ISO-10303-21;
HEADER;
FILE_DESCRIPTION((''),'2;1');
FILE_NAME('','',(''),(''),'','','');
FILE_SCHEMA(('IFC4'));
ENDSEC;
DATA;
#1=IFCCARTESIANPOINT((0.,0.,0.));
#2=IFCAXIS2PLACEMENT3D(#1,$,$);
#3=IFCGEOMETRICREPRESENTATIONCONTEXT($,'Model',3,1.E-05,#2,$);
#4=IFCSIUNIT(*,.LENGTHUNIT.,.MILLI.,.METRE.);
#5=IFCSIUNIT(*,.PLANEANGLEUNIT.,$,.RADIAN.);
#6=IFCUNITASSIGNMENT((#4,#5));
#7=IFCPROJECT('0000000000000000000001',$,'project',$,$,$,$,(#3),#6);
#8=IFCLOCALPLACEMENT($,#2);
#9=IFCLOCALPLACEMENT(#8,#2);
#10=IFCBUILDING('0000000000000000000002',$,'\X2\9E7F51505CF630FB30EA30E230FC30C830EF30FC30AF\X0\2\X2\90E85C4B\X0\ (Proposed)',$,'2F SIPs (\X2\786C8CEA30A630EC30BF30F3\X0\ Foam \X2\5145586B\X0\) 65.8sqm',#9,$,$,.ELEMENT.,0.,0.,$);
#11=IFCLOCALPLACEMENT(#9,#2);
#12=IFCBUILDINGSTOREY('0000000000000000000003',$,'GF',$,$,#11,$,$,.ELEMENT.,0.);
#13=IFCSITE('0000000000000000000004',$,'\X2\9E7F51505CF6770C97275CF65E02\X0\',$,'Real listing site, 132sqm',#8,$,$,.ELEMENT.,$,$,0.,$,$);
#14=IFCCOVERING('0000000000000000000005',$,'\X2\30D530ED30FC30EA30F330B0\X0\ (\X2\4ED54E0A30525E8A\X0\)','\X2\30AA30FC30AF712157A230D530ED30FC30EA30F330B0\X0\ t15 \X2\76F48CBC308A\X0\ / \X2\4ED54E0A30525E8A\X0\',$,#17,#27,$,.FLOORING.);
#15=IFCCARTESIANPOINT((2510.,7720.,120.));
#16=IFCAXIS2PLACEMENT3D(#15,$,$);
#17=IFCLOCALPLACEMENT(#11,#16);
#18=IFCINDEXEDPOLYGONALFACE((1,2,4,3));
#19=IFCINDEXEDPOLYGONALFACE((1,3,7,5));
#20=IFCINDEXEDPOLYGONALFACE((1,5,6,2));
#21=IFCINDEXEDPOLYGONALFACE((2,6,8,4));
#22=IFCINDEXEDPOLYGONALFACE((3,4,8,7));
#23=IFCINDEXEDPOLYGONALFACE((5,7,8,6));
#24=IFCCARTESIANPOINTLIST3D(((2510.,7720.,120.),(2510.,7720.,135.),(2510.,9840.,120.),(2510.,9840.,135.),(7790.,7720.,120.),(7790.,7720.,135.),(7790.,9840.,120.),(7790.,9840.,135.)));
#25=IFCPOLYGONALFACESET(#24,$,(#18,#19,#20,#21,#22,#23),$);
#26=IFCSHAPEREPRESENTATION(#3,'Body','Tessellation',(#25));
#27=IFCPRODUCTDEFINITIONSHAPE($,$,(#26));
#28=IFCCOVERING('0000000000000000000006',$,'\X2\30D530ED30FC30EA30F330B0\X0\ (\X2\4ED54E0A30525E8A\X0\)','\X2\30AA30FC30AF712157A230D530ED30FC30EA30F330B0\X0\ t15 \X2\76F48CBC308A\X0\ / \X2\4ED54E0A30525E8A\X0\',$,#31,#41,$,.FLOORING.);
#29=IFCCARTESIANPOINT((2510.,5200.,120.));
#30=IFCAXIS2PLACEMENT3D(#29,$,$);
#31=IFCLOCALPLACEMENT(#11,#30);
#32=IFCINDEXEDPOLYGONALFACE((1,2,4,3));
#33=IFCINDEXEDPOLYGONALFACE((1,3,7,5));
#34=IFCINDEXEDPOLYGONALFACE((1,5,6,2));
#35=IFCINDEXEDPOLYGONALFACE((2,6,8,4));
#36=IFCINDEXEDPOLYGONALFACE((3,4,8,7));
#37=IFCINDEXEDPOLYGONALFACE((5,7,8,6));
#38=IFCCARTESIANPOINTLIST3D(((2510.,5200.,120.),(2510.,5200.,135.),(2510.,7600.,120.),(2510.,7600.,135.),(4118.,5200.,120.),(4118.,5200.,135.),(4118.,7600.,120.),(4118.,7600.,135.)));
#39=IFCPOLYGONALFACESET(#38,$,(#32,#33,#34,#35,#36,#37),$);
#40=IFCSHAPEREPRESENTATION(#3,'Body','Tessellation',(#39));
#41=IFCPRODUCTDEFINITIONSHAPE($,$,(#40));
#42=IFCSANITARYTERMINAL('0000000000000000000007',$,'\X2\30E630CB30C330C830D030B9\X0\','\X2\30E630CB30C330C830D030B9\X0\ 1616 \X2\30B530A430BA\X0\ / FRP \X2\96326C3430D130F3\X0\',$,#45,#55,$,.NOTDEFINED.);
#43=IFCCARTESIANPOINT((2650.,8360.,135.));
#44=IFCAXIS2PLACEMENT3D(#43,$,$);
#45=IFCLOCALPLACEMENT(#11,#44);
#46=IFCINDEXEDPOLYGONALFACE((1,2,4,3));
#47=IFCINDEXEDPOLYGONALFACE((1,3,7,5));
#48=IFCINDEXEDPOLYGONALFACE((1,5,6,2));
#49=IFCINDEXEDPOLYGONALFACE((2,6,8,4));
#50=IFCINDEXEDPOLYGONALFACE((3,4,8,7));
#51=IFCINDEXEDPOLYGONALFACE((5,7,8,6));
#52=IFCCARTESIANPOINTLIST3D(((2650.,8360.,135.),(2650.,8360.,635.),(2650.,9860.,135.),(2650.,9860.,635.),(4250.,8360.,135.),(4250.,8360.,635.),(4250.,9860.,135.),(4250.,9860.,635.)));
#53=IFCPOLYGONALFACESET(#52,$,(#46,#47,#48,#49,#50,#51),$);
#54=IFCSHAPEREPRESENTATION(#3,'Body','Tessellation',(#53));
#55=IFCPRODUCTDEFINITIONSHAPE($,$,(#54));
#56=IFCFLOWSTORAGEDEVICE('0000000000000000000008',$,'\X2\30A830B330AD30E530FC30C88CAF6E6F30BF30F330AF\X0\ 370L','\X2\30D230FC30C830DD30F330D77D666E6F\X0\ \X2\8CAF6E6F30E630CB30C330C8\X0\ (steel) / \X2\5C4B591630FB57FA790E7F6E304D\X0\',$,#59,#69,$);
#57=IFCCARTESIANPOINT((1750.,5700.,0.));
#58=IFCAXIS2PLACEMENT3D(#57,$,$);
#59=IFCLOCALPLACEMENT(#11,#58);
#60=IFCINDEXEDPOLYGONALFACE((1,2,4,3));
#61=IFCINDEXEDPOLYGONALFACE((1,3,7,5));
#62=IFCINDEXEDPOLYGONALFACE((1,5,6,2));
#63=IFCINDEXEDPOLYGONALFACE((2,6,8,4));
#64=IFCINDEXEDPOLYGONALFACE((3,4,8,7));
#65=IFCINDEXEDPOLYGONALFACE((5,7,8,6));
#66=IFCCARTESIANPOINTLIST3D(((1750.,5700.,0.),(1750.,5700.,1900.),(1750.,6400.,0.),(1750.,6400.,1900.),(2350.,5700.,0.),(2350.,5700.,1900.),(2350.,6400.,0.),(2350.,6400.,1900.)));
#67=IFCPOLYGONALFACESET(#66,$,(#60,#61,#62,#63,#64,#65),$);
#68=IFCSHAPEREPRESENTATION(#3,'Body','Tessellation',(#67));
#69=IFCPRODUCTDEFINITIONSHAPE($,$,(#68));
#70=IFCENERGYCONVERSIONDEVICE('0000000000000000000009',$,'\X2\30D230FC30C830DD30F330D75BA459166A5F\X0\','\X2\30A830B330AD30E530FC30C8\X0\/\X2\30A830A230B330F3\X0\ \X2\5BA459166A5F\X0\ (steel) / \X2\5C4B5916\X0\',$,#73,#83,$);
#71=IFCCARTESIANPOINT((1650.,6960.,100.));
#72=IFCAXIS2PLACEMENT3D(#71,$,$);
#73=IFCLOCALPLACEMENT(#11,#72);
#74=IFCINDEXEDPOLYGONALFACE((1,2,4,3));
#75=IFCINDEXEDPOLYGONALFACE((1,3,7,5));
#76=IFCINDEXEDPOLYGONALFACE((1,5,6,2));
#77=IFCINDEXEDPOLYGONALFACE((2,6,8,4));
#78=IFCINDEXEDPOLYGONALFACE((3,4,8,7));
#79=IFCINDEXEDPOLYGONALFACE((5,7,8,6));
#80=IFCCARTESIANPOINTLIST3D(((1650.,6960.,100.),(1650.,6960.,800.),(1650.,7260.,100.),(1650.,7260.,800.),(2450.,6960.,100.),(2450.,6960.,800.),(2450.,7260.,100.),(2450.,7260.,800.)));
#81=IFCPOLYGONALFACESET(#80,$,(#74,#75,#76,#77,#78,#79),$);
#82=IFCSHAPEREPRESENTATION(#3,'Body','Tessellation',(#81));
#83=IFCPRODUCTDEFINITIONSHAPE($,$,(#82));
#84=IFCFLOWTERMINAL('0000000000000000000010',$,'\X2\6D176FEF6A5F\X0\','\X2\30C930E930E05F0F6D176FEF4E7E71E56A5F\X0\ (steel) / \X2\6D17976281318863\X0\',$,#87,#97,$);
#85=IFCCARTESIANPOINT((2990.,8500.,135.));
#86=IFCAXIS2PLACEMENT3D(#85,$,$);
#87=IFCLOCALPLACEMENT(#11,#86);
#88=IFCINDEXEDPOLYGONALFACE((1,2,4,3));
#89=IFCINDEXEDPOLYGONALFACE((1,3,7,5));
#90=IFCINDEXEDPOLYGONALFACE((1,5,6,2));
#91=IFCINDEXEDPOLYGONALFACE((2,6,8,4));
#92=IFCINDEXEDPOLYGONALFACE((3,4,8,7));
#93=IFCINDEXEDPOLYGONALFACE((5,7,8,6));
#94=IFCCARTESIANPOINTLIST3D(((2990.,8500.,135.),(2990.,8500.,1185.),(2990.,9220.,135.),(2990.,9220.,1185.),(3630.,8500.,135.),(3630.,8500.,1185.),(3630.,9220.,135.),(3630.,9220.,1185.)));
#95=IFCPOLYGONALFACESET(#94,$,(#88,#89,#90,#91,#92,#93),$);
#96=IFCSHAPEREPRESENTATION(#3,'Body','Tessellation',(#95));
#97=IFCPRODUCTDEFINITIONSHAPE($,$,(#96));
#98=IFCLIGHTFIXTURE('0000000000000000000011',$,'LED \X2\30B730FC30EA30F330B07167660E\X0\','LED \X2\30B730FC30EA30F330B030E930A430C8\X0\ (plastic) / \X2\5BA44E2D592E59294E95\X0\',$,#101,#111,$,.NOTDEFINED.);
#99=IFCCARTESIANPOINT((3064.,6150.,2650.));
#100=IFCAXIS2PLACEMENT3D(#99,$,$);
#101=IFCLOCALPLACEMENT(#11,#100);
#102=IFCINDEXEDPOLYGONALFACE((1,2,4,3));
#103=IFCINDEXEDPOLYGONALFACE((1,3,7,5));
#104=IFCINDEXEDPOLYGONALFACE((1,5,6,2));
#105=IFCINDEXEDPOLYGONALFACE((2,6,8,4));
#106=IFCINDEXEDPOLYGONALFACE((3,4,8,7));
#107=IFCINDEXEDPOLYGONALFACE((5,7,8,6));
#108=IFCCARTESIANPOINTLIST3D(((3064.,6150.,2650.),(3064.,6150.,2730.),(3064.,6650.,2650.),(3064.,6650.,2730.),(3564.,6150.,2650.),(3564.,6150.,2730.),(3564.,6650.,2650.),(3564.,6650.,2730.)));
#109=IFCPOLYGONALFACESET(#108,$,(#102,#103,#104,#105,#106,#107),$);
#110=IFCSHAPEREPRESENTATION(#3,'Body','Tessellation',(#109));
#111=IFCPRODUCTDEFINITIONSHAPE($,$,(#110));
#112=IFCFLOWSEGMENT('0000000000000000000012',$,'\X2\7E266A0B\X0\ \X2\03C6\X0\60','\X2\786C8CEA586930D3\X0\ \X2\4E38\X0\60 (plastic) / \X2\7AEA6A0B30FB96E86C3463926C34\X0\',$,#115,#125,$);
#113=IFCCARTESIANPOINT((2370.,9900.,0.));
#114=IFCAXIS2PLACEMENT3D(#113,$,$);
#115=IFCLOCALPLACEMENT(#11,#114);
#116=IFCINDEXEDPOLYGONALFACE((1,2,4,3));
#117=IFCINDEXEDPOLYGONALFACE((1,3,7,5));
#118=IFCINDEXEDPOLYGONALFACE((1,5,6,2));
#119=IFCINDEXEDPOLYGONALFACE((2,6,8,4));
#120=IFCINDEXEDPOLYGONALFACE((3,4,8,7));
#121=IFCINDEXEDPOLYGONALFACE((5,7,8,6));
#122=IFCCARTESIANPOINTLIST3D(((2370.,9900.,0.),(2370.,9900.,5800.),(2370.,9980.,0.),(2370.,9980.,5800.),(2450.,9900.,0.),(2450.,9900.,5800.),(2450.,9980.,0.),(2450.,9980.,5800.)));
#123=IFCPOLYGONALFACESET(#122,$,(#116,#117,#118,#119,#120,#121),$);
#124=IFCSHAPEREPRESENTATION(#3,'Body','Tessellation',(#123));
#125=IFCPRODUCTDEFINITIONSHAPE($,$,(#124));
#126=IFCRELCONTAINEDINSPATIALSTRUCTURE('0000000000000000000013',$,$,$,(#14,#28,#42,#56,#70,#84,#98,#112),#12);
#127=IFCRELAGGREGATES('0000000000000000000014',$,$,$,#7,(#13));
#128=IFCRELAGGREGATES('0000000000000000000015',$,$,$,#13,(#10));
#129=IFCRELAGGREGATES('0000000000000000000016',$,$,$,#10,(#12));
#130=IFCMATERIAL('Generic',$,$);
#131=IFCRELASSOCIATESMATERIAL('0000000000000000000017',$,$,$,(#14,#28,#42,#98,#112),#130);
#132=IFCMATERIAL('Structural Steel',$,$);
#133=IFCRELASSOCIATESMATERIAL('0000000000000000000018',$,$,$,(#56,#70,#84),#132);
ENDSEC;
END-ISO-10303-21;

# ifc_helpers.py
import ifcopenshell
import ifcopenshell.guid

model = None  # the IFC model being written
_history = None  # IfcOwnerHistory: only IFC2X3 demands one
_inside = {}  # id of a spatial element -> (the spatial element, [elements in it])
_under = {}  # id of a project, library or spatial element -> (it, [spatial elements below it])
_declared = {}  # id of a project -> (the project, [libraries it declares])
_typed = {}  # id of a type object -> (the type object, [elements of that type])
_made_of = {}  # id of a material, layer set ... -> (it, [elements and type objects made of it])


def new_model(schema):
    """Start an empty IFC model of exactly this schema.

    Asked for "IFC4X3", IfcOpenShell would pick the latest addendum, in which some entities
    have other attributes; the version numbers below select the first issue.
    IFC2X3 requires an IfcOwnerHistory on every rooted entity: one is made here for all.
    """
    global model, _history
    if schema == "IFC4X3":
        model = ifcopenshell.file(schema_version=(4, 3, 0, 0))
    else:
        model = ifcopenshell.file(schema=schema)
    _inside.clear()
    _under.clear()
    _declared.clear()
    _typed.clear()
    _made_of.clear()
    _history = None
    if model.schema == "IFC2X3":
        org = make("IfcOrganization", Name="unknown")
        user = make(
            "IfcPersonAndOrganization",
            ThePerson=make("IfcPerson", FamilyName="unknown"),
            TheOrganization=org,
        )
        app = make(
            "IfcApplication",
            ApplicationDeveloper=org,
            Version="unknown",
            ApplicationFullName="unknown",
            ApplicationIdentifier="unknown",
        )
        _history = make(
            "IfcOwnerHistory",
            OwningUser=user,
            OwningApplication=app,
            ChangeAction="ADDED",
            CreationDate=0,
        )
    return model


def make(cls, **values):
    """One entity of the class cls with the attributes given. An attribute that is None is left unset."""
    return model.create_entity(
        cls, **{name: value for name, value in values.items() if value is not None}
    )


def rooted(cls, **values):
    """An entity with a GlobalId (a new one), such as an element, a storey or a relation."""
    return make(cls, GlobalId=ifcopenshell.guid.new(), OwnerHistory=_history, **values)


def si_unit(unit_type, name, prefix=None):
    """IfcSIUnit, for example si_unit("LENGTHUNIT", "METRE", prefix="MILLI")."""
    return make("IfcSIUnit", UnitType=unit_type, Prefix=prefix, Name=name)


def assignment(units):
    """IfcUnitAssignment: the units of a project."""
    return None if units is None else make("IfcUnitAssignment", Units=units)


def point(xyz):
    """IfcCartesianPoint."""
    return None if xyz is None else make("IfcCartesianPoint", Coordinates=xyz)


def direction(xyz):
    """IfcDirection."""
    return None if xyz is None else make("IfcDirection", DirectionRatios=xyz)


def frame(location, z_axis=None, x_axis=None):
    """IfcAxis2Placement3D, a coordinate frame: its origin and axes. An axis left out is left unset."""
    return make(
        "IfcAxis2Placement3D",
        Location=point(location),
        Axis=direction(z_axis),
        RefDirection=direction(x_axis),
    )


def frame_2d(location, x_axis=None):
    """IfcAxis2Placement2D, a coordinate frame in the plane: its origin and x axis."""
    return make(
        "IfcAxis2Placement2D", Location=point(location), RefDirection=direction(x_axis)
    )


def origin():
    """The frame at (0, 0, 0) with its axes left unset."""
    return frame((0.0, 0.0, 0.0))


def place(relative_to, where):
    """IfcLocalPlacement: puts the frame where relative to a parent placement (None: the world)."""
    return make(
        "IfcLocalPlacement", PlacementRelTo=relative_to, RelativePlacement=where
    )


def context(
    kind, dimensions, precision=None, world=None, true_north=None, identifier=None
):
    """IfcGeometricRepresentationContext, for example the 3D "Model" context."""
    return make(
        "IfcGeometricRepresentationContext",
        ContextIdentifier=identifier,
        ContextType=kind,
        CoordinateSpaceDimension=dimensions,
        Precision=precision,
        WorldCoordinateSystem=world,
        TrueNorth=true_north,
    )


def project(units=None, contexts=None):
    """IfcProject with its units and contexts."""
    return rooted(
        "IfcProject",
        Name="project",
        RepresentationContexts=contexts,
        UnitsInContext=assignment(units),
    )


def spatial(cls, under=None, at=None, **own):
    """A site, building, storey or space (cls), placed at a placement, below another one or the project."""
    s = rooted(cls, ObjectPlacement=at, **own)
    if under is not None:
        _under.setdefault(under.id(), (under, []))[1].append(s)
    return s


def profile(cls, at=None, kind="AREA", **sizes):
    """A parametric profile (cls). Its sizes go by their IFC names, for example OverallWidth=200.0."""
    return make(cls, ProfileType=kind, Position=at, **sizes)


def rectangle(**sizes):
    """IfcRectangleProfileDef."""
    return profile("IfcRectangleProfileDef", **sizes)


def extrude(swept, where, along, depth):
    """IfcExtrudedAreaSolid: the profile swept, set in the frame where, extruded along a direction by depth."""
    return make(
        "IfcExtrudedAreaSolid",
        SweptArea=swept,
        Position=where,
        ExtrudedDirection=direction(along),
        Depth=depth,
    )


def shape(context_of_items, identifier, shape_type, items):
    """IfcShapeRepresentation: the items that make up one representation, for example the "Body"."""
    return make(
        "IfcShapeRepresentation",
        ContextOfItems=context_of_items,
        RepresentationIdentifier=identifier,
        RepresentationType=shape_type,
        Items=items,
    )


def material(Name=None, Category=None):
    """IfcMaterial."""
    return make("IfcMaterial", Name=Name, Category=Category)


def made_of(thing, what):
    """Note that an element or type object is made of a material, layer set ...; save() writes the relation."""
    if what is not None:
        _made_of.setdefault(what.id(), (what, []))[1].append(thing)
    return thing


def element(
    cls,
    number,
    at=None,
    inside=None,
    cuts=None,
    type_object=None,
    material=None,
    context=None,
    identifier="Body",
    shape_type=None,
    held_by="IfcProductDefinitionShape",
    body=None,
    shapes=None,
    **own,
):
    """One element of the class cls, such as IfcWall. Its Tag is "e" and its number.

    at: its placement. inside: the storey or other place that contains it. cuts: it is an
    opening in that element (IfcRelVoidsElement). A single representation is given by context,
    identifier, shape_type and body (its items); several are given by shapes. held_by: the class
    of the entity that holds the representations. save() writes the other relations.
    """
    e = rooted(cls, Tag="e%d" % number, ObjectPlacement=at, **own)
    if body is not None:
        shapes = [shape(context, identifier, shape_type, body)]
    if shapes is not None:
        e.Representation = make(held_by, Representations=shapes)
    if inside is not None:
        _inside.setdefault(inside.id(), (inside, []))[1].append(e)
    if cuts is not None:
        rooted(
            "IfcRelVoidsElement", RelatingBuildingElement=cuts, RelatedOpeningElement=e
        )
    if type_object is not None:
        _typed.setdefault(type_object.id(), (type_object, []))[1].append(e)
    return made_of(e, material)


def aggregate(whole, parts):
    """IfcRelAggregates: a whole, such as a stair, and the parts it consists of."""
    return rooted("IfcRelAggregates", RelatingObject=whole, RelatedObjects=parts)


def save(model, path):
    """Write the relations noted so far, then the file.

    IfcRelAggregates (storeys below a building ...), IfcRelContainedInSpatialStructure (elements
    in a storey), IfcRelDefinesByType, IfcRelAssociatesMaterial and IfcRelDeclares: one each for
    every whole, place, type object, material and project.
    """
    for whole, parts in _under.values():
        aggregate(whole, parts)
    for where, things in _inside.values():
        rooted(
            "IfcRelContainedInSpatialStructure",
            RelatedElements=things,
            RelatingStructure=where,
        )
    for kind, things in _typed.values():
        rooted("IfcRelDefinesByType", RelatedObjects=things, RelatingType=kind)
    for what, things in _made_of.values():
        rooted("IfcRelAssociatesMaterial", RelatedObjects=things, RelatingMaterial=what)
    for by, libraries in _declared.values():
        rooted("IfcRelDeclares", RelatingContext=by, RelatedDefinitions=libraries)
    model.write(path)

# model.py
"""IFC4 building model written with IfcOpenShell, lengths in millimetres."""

from ifc_helpers import new_model, si_unit, frame, frame_2d, origin, place, context, project, spatial, rectangle, extrude, material, element, save


model = new_model("IFC4")

# Units and contexts
model_context = context("Model", 3, precision=1e-05, world=origin())
ifc_project = project(units=[si_unit("LENGTHUNIT", "METRE", prefix="MILLI"), si_unit("PLANEANGLEUNIT", "RADIAN")], contexts=[model_context])

# Site, building, storey
site_placement = place(None, origin())
site = spatial("IfcSite", under=ifc_project, at=site_placement, Name="鹿児島県霧島市", ObjectType="Real listing site, 132sqm", CompositionType="ELEMENT", RefElevation=0.0)
building_placement = place(site_placement, origin())
building = spatial("IfcBuilding", under=site, at=building_placement, Name="鹿児島・リモートワーク2部屋 (Proposed)", ObjectType="2F SIPs (硬質ウレタン Foam 充填) 65.8sqm", CompositionType="ELEMENT", ElevationOfRefHeight=0.0, ElevationOfTerrain=0.0)
storey_placement = place(building_placement, origin())
storey = spatial("IfcBuildingStorey", under=building, at=storey_placement, Name="GF", CompositionType="ELEMENT", Elevation=0.0)

# Coverings
ifc_material_1 = material(Name="Generic")
covering_1_placement = place(storey_placement, frame((2510.0, 7720.0, 120.0)))
element("IfcCovering", 1, at=covering_1_placement, inside=storey, material=ifc_material_1, Name="フローリング (仕上げ床)", Description="オーク無垢フローリング t15 直貼り / 仕上げ床", PredefinedType="FLOORING", context=model_context, shape_type="SweptSolid", body=[
    extrude(rectangle(XDim=5280.0, YDim=2120.0, at=frame_2d((2640.0, 1060.0))), frame((2510.0, 7720.0, 120.0)), (0.0, 0.0, 1.0), 15.0),
])
covering_2_placement = place(storey_placement, frame((2510.0, 5200.0, 120.0)))
element("IfcCovering", 2, at=covering_2_placement, inside=storey, material=ifc_material_1, Name="フローリング (仕上げ床)", Description="オーク無垢フローリング t15 直貼り / 仕上げ床", PredefinedType="FLOORING", context=model_context, shape_type="SweptSolid", body=[
    extrude(rectangle(XDim=1608.0, YDim=2400.0, at=frame_2d((804.0, 1200.0))), frame((2510.0, 5200.0, 120.0)), (0.0, 0.0, 1.0), 15.0),
])

# Sanitary terminal
sanitary_terminal_placement = place(storey_placement, frame((2650.0, 8360.0, 135.0)))
element("IfcSanitaryTerminal", 3, at=sanitary_terminal_placement, inside=storey, material=ifc_material_1, Name="ユニットバス", Description="ユニットバス 1616 サイズ / FRP 防水パン", PredefinedType="NOTDEFINED", context=model_context, shape_type="SweptSolid", body=[
    extrude(rectangle(XDim=1600.0, YDim=1500.0, at=frame_2d((800.0, 750.0))), frame((2650.0, 8360.0, 135.0)), (0.0, 0.0, 1.0), 500.0),
])

# Flow storage device
ifc_material_2 = material(Name="Structural Steel")
flow_storage_device_placement = place(storey_placement, frame((1750.0, 5700.0, 0.0)))
element("IfcFlowStorageDevice", 4, at=flow_storage_device_placement, inside=storey, material=ifc_material_2, Name="エコキュート貯湯タンク 370L", Description="ヒートポンプ給湯 貯湯ユニット (steel) / 屋外・基礎置き", context=model_context, shape_type="SweptSolid", body=[
    extrude(rectangle(XDim=600.0, YDim=700.0, at=frame_2d((300.0, 350.0))), frame((1750.0, 5700.0, 0.0)), (0.0, 0.0, 1.0), 1900.0),
])

# Energy conversion device
energy_conversion_device_placement = place(storey_placement, frame((1650.0, 6960.0, 100.0)))
element("IfcEnergyConversionDevice", 5, at=energy_conversion_device_placement, inside=storey, material=ifc_material_2, Name="ヒートポンプ室外機", Description="エコキュート/エアコン 室外機 (steel) / 屋外", context=model_context, shape_type="SweptSolid", body=[
    extrude(rectangle(XDim=800.0, YDim=300.0, at=frame_2d((400.0, 150.0))), frame((1650.0, 6960.0, 100.0)), (0.0, 0.0, 1.0), 700.0),
])

# Flow terminal
flow_terminal_placement = place(storey_placement, frame((2990.0, 8500.0, 135.0)))
element("IfcFlowTerminal", 6, at=flow_terminal_placement, inside=storey, material=ifc_material_2, Name="洗濯機", Description="ドラム式洗濯乾燥機 (steel) / 洗面脱衣", context=model_context, shape_type="SweptSolid", body=[
    extrude(rectangle(XDim=640.0, YDim=720.0, at=frame_2d((320.0, 360.0))), frame((2990.0, 8500.0, 135.0)), (0.0, 0.0, 1.0), 1050.0),
])

# Light fixture
light_fixture_placement = place(storey_placement, frame((3064.0, 6150.0, 2650.0)))
element("IfcLightFixture", 7, at=light_fixture_placement, inside=storey, material=ifc_material_1, Name="LED シーリング照明", Description="LED シーリングライト (plastic) / 室中央天井", PredefinedType="NOTDEFINED", context=model_context, shape_type="SweptSolid", body=[
    extrude(rectangle(XDim=500.0, YDim=500.0, at=frame_2d((250.0, 250.0))), frame((3064.0, 6150.0, 2650.0)), (0.0, 0.0, 1.0), 80.0),
])

# Flow segment
flow_segment_placement = place(storey_placement, frame((2370.0, 9900.0, 0.0)))
element("IfcFlowSegment", 8, at=flow_segment_placement, inside=storey, material=ifc_material_1, Name="縦樋 φ60", Description="硬質塩ビ 丸60 (plastic) / 竪樋・雨水排水", context=model_context, shape_type="SweptSolid", body=[
    extrude(rectangle(XDim=80.0, YDim=80.0, at=frame_2d((40.0, 40.0))), frame((2370.0, 9900.0, 0.0)), (0.0, 0.0, 1.0), 5800.0),
])

save(model, "model.ifc")
